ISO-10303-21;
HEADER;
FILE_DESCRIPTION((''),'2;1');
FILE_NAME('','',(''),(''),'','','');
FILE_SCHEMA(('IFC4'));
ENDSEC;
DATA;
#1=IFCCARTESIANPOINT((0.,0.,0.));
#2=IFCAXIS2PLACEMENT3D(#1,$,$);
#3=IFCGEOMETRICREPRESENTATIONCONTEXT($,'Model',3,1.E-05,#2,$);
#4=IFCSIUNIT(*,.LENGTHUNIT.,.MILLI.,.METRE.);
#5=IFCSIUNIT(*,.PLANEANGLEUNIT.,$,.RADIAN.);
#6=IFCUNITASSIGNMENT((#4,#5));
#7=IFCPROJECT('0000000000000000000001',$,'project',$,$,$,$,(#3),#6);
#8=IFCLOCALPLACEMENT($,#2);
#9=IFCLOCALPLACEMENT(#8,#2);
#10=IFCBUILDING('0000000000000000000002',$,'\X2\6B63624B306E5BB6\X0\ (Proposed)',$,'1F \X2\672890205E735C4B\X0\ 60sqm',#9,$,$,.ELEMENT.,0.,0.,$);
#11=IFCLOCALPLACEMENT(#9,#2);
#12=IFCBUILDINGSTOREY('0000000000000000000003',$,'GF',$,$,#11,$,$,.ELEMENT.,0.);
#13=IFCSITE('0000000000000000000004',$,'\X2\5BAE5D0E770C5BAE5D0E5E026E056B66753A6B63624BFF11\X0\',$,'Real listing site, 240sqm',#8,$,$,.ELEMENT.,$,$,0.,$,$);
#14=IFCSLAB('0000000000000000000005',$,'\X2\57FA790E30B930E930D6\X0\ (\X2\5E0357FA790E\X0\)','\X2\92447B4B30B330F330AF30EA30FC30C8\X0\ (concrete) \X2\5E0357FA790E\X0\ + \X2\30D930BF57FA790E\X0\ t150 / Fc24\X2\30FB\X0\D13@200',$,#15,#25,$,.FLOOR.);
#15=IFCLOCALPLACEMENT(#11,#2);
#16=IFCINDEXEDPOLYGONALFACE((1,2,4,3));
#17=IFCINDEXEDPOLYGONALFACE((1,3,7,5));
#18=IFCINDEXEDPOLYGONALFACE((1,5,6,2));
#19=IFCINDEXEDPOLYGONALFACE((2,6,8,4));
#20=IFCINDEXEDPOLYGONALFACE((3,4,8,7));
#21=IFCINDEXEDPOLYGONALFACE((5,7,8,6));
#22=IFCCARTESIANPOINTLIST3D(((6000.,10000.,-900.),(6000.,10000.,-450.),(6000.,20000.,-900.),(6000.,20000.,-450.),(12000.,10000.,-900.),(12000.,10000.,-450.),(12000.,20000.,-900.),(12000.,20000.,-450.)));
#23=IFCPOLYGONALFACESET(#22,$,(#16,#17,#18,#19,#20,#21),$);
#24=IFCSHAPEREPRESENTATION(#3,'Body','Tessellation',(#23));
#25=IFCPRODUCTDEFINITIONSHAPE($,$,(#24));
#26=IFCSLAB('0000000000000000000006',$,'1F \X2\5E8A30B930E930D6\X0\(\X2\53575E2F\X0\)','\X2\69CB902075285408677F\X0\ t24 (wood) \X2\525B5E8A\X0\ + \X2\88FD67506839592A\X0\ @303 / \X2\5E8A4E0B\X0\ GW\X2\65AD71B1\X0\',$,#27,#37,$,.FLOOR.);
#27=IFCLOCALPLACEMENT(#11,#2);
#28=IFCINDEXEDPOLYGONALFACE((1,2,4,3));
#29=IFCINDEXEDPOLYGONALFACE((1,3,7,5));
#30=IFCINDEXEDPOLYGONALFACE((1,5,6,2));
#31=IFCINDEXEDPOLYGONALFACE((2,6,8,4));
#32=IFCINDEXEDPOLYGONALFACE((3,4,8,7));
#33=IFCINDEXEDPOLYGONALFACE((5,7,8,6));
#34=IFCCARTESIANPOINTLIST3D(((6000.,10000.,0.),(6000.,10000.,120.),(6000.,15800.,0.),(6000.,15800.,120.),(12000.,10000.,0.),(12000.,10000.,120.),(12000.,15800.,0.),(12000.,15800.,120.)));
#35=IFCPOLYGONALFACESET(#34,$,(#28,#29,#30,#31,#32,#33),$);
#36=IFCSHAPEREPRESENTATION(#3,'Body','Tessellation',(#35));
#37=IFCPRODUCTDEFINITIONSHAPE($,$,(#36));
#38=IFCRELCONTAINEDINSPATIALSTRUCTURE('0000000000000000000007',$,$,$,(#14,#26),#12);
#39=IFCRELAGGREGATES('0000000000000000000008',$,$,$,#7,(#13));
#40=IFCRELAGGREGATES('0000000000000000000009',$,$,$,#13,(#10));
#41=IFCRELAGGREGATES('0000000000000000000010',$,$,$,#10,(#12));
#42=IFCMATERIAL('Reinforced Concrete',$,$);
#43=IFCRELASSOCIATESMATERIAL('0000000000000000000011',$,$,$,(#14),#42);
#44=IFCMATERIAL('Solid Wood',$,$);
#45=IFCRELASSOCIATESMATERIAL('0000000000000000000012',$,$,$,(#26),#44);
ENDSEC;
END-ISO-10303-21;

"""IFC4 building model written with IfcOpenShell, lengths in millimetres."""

from ifc_helpers import new_model, si_unit, frame, frame_2d, origin, place, context, project, spatial, rectangle, extrude, material, element, save


model = new_model("IFC4")

# Units and contexts
model_context = context("Model", 3, precision=1e-05, world=origin())
ifc_project = project(units=[si_unit("LENGTHUNIT", "METRE", prefix="MILLI"), si_unit("PLANEANGLEUNIT", "RADIAN")], contexts=[model_context])

# Site, building, storey
site_placement = place(None, origin())
site = spatial("IfcSite", under=ifc_project, at=site_placement, Name="宮崎県宮崎市清武町正手１", ObjectType="Real listing site, 240sqm", CompositionType="ELEMENT", RefElevation=0.0)
building_placement = place(site_placement, origin())
building = spatial("IfcBuilding", under=site, at=building_placement, Name="正手の家 (Proposed)", ObjectType="1F 木造平屋 60sqm", CompositionType="ELEMENT", ElevationOfRefHeight=0.0, ElevationOfTerrain=0.0)
storey_placement = place(building_placement, origin())
storey = spatial("IfcBuildingStorey", under=building, at=storey_placement, Name="GF", CompositionType="ELEMENT", Elevation=0.0)

# Shared definitions
ifc_material_1 = material(Name="Solid Wood")

# Slabs
ifc_material_2 = material(Name="Reinforced Concrete")
slab_1_placement = place(storey_placement, frame((3000.0, 5000.0, -450.0)))
element("IfcSlab", 1, at=slab_1_placement, inside=storey, material=ifc_material_2, Name="基礎スラブ (布基礎)", Description="鉄筋コンクリート (concrete) 布基礎 + ベタ基礎 t150 / Fc24・D13@200", PredefinedType="FLOOR", context=model_context, shape_type="SweptSolid", body=[
    extrude(rectangle(XDim=6000.0, YDim=10000.0, at=frame_2d((3000.0, 5000.0))), frame((3000.0, 5000.0, -450.0)), (0.0, 0.0, 1.0), 450.0),
])
slab_2_placement = place(storey_placement, frame((3000.0, 5000.0, 0.0)))
element("IfcSlab", 2, at=slab_2_placement, inside=storey, material=ifc_material_1, Name="1F 床スラブ(南帯)", Description="構造用合板 t24 (wood) 剛床 + 製材根太 @303 / 床下 GW断熱", PredefinedType="FLOOR", context=model_context, shape_type="SweptSolid", body=[
    extrude(rectangle(XDim=6000.0, YDim=5800.0, at=frame_2d((3000.0, 2900.0))), frame((3000.0, 5000.0, 0.0)), (0.0, 0.0, 1.0), 120.0),
])

save(model, "model.ifc")
